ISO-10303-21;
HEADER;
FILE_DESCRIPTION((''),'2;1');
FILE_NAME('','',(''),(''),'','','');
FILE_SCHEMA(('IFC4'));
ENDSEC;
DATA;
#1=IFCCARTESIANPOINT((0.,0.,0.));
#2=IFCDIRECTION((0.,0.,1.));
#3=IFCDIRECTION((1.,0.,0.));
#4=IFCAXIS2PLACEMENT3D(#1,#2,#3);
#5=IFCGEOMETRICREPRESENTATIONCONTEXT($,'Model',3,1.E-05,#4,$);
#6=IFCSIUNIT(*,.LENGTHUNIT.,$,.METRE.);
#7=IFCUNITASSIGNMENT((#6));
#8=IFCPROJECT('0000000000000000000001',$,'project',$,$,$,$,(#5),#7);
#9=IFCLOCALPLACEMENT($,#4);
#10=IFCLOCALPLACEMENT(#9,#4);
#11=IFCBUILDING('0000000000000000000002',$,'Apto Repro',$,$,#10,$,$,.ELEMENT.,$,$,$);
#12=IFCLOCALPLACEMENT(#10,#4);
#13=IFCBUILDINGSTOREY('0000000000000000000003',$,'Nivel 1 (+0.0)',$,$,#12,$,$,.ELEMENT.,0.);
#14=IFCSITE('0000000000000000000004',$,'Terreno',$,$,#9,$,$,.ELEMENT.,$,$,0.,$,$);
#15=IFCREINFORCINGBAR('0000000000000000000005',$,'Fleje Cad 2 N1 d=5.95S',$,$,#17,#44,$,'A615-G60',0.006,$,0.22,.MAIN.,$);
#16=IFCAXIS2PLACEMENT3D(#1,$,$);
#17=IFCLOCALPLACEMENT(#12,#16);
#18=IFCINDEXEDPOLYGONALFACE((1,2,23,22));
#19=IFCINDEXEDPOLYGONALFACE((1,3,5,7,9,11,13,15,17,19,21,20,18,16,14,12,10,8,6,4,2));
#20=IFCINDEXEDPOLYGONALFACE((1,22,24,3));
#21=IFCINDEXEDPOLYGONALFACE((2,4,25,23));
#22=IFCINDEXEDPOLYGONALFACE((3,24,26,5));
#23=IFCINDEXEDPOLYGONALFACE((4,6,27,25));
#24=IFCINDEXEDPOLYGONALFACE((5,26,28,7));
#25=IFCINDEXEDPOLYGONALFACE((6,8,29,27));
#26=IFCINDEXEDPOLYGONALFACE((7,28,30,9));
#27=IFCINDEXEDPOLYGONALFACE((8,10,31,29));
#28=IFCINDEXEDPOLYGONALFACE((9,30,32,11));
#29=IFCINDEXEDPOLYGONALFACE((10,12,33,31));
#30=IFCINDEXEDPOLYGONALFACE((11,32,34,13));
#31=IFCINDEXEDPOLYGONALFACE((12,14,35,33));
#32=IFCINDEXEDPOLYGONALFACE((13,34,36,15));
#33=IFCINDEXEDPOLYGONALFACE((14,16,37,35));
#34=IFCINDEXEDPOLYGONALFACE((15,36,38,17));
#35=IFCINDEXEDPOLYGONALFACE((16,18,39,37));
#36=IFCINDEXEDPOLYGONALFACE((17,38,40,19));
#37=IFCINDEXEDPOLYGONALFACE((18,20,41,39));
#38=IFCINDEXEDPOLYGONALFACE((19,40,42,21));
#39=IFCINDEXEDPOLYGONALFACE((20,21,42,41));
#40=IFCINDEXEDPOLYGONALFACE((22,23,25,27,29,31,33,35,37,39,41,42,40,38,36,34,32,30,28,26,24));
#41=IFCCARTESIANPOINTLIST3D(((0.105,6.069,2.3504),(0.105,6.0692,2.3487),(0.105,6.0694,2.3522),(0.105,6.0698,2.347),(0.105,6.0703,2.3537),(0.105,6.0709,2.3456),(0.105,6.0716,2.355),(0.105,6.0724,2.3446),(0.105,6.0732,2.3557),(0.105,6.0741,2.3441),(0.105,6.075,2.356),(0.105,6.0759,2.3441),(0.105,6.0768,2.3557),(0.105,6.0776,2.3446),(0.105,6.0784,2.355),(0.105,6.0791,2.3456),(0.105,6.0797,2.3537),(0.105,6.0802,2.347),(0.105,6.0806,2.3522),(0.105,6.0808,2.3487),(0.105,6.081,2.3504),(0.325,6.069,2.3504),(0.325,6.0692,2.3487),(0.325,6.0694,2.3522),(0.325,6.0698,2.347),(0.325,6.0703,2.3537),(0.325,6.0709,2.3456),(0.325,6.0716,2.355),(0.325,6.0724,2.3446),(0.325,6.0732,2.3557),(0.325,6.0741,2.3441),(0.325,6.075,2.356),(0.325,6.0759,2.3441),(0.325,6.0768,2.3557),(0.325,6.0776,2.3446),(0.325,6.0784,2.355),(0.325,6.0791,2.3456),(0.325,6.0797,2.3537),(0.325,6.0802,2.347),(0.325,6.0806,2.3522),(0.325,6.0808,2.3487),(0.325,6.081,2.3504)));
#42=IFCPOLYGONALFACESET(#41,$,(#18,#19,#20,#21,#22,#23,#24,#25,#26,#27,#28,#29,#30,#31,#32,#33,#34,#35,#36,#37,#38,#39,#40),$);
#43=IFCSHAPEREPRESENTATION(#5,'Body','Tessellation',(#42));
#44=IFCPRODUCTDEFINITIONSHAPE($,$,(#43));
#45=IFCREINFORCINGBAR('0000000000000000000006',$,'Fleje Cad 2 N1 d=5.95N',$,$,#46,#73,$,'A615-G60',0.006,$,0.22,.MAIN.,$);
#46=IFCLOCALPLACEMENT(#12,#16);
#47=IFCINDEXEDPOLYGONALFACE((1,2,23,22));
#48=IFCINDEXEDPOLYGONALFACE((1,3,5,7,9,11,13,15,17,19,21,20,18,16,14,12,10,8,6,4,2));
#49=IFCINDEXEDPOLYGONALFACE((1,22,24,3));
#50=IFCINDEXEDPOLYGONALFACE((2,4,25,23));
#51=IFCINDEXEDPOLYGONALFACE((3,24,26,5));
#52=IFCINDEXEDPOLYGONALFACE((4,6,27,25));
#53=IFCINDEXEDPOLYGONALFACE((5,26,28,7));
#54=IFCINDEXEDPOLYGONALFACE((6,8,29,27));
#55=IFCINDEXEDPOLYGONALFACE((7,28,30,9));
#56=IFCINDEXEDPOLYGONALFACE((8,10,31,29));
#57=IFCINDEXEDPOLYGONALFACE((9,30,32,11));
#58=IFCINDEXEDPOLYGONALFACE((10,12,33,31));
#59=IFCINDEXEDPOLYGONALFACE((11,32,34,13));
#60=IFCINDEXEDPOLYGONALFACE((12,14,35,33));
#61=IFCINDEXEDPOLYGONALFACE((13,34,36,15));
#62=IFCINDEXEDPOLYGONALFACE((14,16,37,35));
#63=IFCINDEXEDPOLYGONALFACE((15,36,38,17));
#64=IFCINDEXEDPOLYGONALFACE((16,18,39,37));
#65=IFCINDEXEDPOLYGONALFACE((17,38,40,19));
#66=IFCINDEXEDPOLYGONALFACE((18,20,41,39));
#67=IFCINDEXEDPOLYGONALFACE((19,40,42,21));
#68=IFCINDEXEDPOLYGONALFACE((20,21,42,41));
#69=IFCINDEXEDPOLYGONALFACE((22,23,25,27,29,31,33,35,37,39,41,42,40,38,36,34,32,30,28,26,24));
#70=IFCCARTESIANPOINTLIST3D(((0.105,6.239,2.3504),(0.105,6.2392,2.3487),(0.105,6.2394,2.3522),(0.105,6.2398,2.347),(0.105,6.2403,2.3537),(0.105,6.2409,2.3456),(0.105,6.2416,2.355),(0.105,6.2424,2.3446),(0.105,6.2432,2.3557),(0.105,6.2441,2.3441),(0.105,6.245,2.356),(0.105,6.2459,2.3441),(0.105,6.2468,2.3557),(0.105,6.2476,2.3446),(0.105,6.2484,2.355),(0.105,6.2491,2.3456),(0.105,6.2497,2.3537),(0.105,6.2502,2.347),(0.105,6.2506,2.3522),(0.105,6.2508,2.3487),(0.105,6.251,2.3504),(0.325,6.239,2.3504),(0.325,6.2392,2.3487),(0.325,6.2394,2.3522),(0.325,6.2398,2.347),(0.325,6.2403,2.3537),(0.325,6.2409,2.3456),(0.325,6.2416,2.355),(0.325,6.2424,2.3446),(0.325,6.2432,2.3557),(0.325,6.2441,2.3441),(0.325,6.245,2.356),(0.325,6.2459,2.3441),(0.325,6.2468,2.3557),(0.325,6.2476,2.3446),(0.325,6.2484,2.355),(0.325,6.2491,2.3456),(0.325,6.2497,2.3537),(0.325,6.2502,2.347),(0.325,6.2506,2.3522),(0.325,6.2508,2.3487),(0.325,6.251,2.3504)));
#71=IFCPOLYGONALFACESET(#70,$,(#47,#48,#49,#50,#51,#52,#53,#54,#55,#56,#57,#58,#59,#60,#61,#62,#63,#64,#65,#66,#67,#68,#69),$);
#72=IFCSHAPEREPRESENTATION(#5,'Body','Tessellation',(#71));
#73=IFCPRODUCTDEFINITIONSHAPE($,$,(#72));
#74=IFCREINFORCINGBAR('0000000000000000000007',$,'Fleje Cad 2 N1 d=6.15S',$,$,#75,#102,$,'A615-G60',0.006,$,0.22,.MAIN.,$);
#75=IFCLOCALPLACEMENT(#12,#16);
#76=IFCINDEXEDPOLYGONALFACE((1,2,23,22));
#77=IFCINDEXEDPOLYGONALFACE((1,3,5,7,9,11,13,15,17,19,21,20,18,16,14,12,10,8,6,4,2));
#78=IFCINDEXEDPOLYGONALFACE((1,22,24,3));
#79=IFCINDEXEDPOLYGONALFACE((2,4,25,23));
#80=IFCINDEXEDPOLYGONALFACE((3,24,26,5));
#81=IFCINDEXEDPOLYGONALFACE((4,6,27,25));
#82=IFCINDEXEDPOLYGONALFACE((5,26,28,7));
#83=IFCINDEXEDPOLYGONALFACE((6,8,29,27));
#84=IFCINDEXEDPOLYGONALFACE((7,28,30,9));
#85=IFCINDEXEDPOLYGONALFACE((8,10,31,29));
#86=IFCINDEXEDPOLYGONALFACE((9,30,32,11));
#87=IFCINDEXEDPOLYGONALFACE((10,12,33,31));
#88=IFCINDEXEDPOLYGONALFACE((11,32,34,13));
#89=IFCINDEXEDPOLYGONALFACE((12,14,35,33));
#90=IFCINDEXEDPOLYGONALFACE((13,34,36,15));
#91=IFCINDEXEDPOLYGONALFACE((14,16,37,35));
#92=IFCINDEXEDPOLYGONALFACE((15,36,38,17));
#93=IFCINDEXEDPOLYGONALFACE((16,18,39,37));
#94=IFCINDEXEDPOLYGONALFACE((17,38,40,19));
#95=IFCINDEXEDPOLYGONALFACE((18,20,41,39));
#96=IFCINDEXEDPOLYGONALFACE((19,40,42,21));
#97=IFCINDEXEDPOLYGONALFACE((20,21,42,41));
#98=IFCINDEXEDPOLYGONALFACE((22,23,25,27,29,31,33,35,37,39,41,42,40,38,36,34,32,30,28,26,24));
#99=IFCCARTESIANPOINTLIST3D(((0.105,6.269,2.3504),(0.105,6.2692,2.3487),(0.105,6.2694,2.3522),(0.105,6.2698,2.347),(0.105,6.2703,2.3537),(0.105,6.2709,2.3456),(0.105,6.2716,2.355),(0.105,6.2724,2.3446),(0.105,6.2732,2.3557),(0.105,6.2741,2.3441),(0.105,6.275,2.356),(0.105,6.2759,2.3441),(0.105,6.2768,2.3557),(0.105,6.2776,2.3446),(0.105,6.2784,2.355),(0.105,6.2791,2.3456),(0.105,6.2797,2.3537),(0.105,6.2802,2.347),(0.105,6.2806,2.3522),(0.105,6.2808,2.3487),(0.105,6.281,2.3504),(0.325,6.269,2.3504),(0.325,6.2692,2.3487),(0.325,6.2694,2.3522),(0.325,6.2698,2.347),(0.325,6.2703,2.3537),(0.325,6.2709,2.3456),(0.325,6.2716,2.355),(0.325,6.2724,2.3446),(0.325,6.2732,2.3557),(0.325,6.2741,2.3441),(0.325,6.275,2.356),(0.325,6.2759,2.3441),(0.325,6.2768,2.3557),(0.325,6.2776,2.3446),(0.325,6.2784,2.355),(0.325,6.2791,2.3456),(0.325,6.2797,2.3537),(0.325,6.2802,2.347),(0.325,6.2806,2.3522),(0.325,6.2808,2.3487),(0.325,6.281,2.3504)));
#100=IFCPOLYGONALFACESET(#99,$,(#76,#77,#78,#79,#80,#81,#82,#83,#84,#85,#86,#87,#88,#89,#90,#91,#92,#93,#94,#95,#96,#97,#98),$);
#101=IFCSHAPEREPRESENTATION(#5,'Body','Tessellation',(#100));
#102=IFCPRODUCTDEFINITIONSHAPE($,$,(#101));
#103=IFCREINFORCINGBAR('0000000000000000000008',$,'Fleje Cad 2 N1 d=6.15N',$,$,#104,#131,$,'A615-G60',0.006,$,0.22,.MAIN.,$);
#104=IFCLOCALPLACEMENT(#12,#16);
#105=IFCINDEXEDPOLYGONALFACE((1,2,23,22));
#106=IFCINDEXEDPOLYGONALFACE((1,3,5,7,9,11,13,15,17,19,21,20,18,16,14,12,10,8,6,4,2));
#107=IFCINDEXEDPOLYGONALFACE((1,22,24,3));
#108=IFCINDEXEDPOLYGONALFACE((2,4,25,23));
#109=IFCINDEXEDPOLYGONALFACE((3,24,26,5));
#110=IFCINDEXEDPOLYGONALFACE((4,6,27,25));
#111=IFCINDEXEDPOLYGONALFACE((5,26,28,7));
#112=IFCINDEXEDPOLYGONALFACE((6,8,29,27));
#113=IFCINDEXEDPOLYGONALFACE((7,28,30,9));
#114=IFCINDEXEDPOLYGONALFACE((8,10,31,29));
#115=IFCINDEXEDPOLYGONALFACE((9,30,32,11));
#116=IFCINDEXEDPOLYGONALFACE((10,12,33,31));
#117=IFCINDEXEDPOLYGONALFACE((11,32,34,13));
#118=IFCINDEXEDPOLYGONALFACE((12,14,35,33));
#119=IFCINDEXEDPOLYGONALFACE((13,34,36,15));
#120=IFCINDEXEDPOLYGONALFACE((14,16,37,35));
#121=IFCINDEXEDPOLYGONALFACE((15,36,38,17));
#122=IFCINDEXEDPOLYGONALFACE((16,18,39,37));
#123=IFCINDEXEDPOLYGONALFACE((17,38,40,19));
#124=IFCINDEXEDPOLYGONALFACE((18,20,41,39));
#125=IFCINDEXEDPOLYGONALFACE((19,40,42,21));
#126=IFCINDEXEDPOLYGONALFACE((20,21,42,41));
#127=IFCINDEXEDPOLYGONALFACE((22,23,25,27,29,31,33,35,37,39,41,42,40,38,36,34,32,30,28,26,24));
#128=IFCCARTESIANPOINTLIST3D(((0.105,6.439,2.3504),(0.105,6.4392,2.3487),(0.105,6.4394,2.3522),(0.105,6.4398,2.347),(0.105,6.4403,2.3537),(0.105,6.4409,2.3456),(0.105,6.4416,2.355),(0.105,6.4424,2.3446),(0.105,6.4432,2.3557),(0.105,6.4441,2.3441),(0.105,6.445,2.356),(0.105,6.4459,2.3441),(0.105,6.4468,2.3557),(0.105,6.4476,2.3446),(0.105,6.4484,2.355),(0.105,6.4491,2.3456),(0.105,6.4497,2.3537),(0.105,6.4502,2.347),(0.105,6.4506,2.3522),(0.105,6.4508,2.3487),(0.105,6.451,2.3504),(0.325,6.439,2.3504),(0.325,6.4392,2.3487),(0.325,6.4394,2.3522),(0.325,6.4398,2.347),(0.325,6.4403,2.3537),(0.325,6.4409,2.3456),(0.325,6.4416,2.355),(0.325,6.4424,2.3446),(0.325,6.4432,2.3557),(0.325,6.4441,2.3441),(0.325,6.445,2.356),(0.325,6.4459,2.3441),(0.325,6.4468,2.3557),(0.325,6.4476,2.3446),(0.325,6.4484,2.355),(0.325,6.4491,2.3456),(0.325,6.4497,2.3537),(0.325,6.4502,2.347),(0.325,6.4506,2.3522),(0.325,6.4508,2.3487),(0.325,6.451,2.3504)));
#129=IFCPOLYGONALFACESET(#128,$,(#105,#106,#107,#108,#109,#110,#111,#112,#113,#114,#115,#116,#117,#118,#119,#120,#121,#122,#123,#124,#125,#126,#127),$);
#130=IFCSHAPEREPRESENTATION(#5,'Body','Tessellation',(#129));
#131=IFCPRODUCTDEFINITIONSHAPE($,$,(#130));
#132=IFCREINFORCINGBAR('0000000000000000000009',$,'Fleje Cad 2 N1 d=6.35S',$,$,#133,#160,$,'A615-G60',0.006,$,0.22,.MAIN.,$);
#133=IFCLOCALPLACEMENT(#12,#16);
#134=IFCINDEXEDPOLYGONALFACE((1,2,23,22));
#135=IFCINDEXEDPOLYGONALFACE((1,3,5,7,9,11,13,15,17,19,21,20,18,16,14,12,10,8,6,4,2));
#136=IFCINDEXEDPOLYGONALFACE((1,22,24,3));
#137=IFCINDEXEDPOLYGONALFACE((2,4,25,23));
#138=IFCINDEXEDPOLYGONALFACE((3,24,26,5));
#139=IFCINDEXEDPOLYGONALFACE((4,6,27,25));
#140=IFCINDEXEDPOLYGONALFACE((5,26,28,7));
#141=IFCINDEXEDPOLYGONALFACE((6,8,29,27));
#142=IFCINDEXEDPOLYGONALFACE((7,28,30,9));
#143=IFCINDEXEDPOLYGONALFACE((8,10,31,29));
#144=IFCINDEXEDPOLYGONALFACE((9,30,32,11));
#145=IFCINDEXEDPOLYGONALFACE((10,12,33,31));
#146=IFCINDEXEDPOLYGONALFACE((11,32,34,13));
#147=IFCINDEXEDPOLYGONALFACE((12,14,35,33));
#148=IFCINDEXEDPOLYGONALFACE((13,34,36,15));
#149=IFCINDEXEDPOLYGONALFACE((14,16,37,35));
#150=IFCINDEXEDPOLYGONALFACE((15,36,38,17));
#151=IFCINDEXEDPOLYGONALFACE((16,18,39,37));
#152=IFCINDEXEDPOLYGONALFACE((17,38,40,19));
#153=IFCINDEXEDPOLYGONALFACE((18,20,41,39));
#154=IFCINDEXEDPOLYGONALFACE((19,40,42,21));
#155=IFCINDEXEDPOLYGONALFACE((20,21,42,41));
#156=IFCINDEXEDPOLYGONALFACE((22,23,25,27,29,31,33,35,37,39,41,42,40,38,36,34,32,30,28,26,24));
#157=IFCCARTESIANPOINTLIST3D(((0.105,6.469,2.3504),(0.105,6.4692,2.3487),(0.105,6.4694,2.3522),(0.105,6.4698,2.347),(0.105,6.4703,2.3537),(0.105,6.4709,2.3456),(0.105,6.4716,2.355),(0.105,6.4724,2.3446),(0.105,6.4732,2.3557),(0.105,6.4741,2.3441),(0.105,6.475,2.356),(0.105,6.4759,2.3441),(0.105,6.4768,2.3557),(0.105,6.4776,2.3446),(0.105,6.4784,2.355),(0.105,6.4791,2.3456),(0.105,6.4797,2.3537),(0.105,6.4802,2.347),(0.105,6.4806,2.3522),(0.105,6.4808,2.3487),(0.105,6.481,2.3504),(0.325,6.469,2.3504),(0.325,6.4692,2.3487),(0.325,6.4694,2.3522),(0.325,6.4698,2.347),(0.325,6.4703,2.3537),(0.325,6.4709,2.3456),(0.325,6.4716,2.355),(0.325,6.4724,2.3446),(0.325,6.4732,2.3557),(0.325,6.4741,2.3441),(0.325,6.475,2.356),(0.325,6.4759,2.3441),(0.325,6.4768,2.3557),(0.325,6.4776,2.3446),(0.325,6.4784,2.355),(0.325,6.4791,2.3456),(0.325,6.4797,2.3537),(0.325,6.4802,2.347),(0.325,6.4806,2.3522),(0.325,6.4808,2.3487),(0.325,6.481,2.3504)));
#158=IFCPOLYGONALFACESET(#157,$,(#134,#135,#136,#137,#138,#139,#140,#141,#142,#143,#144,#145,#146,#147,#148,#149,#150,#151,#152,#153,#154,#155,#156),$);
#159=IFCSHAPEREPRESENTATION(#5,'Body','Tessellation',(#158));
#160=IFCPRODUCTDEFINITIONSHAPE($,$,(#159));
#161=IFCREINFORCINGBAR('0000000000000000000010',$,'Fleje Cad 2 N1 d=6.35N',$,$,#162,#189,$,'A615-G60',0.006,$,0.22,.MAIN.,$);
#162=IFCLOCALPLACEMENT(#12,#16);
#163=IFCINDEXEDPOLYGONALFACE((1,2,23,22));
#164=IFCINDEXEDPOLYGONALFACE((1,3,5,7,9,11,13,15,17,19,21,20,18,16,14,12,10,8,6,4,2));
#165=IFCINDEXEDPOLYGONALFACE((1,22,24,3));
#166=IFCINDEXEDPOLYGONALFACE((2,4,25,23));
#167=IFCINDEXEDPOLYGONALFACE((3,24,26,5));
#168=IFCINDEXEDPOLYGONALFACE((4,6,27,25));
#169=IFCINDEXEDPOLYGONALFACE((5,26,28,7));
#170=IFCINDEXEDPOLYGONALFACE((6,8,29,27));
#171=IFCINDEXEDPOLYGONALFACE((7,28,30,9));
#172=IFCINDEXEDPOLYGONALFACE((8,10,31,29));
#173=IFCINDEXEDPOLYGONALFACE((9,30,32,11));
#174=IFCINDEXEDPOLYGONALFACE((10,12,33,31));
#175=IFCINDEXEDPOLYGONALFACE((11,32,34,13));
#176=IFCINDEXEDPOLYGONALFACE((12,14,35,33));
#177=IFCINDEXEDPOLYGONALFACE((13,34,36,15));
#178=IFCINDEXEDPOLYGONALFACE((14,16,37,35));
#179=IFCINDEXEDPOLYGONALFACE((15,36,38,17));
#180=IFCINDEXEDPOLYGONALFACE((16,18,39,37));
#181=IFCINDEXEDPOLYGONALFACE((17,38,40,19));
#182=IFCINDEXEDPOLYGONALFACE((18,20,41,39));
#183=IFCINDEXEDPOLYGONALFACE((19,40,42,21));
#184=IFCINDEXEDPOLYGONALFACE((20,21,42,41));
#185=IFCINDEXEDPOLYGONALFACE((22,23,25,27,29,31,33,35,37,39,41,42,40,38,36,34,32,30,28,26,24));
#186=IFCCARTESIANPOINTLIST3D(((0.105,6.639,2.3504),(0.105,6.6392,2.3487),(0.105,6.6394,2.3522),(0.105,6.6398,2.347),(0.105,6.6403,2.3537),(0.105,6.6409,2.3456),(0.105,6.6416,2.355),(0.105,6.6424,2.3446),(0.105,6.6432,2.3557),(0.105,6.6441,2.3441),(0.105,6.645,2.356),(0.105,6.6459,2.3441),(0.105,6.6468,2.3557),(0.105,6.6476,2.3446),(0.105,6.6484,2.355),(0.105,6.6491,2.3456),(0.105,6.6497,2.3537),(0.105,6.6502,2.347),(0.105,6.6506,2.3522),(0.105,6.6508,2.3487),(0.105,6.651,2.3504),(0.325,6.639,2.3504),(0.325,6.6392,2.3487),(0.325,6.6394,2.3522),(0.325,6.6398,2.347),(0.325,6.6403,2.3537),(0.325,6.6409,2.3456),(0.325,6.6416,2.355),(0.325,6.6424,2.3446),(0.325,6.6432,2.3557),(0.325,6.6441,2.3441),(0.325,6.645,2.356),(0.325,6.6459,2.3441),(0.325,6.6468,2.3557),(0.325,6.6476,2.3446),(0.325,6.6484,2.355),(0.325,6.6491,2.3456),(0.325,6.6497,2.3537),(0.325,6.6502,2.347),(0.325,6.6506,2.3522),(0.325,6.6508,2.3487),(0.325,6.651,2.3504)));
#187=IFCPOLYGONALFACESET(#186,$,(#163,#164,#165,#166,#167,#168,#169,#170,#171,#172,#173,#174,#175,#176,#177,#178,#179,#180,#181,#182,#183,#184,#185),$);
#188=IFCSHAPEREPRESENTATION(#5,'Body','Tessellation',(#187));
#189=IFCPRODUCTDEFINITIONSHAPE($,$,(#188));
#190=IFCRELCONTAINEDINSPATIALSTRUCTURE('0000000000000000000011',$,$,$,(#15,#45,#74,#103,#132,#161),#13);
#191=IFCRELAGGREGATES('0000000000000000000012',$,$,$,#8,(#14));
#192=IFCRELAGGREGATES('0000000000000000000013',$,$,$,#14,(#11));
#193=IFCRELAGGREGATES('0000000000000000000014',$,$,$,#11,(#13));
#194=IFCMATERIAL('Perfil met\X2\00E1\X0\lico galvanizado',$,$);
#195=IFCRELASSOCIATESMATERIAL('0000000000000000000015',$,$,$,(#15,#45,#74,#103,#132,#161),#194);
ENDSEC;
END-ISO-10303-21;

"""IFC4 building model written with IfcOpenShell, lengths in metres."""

from ifc_helpers import new_model, si_unit, frame, origin_with_axes, origin_2d_with_axis, place, context, project, spatial, circle, extrude, material, element, save


model = new_model("IFC4")

# Units and contexts
model_context = context("Model", 3, precision=1e-05, world=origin_with_axes())
ifc_project = project(units=[si_unit("LENGTHUNIT", "METRE")], contexts=[model_context])

# Site, building, storey
site_placement = place(None, origin_with_axes())
site = spatial("IfcSite", under=ifc_project, at=site_placement, Name="Terreno", CompositionType="ELEMENT", RefElevation=0.0)
building_placement = place(site_placement, origin_with_axes())
building = spatial("IfcBuilding", under=site, at=building_placement, Name="Apto Repro", CompositionType="ELEMENT")
storey_placement = place(building_placement, origin_with_axes())
storey = spatial("IfcBuildingStorey", under=building, at=storey_placement, Name="Nivel 1 (+0.0)", CompositionType="ELEMENT", Elevation=0.0)

# Reinforcing bars
ifc_material = material(Name="Perfil metálico galvanizado")
reinforcing_bar_1_placement = place(storey_placement, origin_with_axes())
element("IfcReinforcingBar", 1, at=reinforcing_bar_1_placement, inside=storey, material=ifc_material, Name="Fleje Cad 2 N1 d=5.95S", SteelGrade="A615-G60", BarLength=0.22, NominalDiameter=0.006, PredefinedType="MAIN", context=model_context, shape_type="SweptSolid", body=[
    extrude(circle(Radius=0.006, at=origin_2d_with_axis()), frame((0.105, 6.075, 2.35), z_axis=(1.0, 0.0, 0.0), x_axis=(0.0, 0.0, 1.0)), (0.0, 0.0, 1.0), 0.22),
])
reinforcing_bar_2_placement = place(storey_placement, origin_with_axes())
element("IfcReinforcingBar", 2, at=reinforcing_bar_2_placement, inside=storey, material=ifc_material, Name="Fleje Cad 2 N1 d=5.95N", SteelGrade="A615-G60", BarLength=0.22, NominalDiameter=0.006, PredefinedType="MAIN", context=model_context, shape_type="SweptSolid", body=[
    extrude(circle(Radius=0.006, at=origin_2d_with_axis()), frame((0.105, 6.245, 2.35), z_axis=(1.0, 0.0, 0.0), x_axis=(0.0, 0.0, 1.0)), (0.0, 0.0, 1.0), 0.22),
])
reinforcing_bar_3_placement = place(storey_placement, origin_with_axes())
element("IfcReinforcingBar", 3, at=reinforcing_bar_3_placement, inside=storey, material=ifc_material, Name="Fleje Cad 2 N1 d=6.15S", SteelGrade="A615-G60", BarLength=0.22, NominalDiameter=0.006, PredefinedType="MAIN", context=model_context, shape_type="SweptSolid", body=[
    extrude(circle(Radius=0.006, at=origin_2d_with_axis()), frame((0.105, 6.275, 2.35), z_axis=(1.0, 0.0, 0.0), x_axis=(0.0, 0.0, 1.0)), (0.0, 0.0, 1.0), 0.22),
])
reinforcing_bar_4_placement = place(storey_placement, origin_with_axes())
element("IfcReinforcingBar", 4, at=reinforcing_bar_4_placement, inside=storey, material=ifc_material, Name="Fleje Cad 2 N1 d=6.15N", SteelGrade="A615-G60", BarLength=0.22, NominalDiameter=0.006, PredefinedType="MAIN", context=model_context, shape_type="SweptSolid", body=[
    extrude(circle(Radius=0.006, at=origin_2d_with_axis()), frame((0.105, 6.445, 2.35), z_axis=(1.0, 0.0, 0.0), x_axis=(0.0, 0.0, 1.0)), (0.0, 0.0, 1.0), 0.22),
])
reinforcing_bar_5_placement = place(storey_placement, origin_with_axes())
element("IfcReinforcingBar", 5, at=reinforcing_bar_5_placement, inside=storey, material=ifc_material, Name="Fleje Cad 2 N1 d=6.35S", SteelGrade="A615-G60", BarLength=0.22, NominalDiameter=0.006, PredefinedType="MAIN", context=model_context, shape_type="SweptSolid", body=[
    extrude(circle(Radius=0.006, at=origin_2d_with_axis()), frame((0.105, 6.475, 2.35), z_axis=(1.0, 0.0, 0.0), x_axis=(0.0, 0.0, 1.0)), (0.0, 0.0, 1.0), 0.22),
])
reinforcing_bar_6_placement = place(storey_placement, origin_with_axes())
element("IfcReinforcingBar", 6, at=reinforcing_bar_6_placement, inside=storey, material=ifc_material, Name="Fleje Cad 2 N1 d=6.35N", SteelGrade="A615-G60", BarLength=0.22, NominalDiameter=0.006, PredefinedType="MAIN", context=model_context, shape_type="SweptSolid", body=[
    extrude(circle(Radius=0.006, at=origin_2d_with_axis()), frame((0.105, 6.645, 2.35), z_axis=(1.0, 0.0, 0.0), x_axis=(0.0, 0.0, 1.0)), (0.0, 0.0, 1.0), 0.22),
])

save(model, "model.ifc")
